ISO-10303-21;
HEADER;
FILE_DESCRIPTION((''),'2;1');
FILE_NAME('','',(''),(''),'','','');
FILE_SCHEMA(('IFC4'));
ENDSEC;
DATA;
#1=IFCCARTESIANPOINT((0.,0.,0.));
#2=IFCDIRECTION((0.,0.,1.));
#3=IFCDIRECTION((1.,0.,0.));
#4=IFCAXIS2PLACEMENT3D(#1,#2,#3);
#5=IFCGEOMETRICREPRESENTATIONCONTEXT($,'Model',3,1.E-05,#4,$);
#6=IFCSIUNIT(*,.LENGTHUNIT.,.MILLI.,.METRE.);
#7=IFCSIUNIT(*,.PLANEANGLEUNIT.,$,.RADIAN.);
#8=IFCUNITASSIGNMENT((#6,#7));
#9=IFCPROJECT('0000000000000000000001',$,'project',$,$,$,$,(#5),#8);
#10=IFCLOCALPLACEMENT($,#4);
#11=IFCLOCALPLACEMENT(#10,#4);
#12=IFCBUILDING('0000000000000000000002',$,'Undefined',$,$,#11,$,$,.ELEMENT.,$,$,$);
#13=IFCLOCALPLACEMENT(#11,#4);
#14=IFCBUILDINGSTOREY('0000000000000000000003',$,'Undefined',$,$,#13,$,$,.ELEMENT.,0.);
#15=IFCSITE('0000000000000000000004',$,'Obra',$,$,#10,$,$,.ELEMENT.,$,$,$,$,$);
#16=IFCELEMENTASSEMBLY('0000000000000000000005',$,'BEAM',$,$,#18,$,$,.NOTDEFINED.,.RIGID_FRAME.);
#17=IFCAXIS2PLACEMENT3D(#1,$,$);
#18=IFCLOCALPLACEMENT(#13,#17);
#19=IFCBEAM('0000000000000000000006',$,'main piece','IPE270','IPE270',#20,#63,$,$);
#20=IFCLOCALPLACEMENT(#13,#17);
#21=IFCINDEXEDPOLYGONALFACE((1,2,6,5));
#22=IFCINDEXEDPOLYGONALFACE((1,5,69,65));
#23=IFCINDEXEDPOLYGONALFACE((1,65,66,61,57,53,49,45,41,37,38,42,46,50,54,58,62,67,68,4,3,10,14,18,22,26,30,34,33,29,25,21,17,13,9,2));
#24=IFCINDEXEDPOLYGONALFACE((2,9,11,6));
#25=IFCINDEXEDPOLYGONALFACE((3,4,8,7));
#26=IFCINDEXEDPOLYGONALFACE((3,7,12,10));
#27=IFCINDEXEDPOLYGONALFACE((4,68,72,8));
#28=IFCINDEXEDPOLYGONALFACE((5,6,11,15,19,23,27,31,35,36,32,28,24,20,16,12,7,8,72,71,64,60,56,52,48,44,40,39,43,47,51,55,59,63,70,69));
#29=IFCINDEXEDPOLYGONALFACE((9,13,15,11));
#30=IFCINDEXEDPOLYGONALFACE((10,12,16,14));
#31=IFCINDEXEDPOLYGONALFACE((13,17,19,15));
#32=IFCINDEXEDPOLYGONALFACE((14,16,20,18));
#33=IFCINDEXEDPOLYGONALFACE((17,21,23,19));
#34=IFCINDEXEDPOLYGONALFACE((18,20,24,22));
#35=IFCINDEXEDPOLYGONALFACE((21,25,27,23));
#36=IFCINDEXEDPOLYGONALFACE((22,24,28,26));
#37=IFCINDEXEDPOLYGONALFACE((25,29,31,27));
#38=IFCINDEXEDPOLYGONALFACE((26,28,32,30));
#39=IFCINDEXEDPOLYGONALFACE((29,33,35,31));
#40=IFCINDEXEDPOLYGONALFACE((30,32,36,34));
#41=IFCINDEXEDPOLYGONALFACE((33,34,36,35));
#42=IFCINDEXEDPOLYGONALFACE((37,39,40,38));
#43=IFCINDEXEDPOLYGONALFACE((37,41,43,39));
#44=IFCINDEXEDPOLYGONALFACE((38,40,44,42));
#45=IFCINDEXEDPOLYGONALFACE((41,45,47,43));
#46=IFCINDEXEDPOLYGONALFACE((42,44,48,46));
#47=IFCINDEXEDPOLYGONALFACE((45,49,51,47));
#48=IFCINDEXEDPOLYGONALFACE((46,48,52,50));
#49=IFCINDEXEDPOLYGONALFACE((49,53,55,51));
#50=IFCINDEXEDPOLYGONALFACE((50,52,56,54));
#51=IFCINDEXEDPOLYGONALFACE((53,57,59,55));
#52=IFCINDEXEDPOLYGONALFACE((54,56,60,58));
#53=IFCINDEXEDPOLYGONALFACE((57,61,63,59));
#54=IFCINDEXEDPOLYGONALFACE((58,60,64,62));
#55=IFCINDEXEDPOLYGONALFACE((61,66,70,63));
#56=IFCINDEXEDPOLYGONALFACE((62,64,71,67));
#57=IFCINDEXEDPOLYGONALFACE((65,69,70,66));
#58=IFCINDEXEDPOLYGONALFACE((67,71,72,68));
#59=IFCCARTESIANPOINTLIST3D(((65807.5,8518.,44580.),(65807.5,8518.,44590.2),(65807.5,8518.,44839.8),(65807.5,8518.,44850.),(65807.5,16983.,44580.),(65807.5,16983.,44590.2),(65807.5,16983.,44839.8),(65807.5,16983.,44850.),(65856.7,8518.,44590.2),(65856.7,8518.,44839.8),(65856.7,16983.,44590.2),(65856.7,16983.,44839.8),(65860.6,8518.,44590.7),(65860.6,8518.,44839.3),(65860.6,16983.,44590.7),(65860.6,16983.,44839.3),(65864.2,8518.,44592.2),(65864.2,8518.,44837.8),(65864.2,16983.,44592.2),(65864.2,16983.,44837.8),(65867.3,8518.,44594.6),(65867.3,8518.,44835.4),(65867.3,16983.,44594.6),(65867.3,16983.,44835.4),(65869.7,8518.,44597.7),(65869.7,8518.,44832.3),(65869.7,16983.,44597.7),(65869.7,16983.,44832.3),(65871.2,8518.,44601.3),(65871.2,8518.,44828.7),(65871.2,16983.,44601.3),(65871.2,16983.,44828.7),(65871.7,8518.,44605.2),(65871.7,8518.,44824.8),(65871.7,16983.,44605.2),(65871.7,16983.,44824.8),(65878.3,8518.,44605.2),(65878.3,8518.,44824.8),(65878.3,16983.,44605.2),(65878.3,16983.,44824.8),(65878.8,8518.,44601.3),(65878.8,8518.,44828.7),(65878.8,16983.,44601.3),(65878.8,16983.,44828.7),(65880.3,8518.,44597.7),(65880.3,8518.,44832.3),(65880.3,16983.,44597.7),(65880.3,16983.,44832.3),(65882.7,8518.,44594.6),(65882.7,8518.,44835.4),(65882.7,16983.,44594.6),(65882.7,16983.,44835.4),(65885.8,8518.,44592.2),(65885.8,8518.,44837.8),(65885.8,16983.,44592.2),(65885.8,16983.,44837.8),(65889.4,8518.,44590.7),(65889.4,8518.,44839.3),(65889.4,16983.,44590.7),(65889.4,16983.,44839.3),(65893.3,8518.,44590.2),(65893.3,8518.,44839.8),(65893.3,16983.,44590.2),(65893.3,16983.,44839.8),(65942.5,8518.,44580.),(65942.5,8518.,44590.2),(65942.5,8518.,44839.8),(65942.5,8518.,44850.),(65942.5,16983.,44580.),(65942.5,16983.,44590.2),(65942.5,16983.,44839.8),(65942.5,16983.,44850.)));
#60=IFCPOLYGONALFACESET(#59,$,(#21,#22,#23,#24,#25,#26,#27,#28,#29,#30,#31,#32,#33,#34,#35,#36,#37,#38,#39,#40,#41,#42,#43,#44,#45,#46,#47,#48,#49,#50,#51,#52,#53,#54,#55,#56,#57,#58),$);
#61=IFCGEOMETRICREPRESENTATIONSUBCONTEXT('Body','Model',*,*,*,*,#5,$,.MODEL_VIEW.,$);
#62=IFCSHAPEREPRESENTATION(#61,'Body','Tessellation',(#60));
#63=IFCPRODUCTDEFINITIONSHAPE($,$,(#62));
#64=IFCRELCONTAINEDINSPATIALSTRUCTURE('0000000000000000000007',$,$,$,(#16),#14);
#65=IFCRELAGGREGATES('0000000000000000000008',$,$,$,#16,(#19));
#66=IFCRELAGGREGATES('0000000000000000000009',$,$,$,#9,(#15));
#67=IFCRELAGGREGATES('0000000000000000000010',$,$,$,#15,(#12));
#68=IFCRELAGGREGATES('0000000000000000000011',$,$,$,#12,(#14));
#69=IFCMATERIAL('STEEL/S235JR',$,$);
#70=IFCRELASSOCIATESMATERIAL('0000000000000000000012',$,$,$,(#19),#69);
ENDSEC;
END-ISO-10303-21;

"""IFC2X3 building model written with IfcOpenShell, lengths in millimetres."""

from ifc_helpers import new_model, si_unit, frame, origin_with_axes, origin_2d_with_axis, place, context, subcontext, project, spatial, i_section, extrude, material, element, aggregate, save


model = new_model("IFC2X3")

# Units and contexts
model_context = context("Model", 3, precision=1e-05, world=origin_with_axes())
body_context = subcontext(model_context, "Body", "Model", "MODEL_VIEW")
ifc_project = project(units=[si_unit("LENGTHUNIT", "METRE", prefix="MILLI"), si_unit("PLANEANGLEUNIT", "RADIAN")], contexts=[model_context])

# Site, building, storey
site_placement = place(None, origin_with_axes())
site = spatial("IfcSite", under=ifc_project, at=site_placement, Name="Obra", CompositionType="ELEMENT")
building_placement = place(site_placement, origin_with_axes())
building = spatial("IfcBuilding", under=site, at=building_placement, Name="Undefined", CompositionType="ELEMENT")
storey_placement = place(building_placement, origin_with_axes())
storey = spatial("IfcBuildingStorey", under=building, at=storey_placement, Name="Undefined", CompositionType="ELEMENT", Elevation=0.0)

# Shared definitions
ifc_material_1 = material(Name="STEEL/S235JR")

# Element assembly, beam
assembly_1_placement = place(storey_placement, origin_with_axes())
assembly_1 = element("IfcElementAssembly", 1, at=assembly_1_placement, inside=storey, Name="BEAM", AssemblyPlace="NOTDEFINED", PredefinedType="RIGID_FRAME")
beam_1_placement = place(assembly_1_placement, frame((65875.0, 16983.0, 44715.0), z_axis=(0.0, 0.0, 1.0), x_axis=(0.0, -1.0, 0.0)))
beam_1 = element("IfcBeam", 2, at=beam_1_placement, material=ifc_material_1, Name="main piece", Description="IPE270", ObjectType="IPE270", context=body_context, shape_type="SweptSolid", body=[
    extrude(i_section(OverallWidth=135.0, OverallDepth=270.0, WebThickness=6.6, FlangeThickness=10.2, FilletRadius=15.0, at=origin_2d_with_axis()), frame((8465.0, 0.0, 0.0), z_axis=(-1.0, 0.0, 0.0), x_axis=(0.0, -1.0, 0.0)), (0.0, 0.0, 1.0), 8465.0),
])
aggregate(assembly_1, [beam_1])

save(model, "model.ifc")
